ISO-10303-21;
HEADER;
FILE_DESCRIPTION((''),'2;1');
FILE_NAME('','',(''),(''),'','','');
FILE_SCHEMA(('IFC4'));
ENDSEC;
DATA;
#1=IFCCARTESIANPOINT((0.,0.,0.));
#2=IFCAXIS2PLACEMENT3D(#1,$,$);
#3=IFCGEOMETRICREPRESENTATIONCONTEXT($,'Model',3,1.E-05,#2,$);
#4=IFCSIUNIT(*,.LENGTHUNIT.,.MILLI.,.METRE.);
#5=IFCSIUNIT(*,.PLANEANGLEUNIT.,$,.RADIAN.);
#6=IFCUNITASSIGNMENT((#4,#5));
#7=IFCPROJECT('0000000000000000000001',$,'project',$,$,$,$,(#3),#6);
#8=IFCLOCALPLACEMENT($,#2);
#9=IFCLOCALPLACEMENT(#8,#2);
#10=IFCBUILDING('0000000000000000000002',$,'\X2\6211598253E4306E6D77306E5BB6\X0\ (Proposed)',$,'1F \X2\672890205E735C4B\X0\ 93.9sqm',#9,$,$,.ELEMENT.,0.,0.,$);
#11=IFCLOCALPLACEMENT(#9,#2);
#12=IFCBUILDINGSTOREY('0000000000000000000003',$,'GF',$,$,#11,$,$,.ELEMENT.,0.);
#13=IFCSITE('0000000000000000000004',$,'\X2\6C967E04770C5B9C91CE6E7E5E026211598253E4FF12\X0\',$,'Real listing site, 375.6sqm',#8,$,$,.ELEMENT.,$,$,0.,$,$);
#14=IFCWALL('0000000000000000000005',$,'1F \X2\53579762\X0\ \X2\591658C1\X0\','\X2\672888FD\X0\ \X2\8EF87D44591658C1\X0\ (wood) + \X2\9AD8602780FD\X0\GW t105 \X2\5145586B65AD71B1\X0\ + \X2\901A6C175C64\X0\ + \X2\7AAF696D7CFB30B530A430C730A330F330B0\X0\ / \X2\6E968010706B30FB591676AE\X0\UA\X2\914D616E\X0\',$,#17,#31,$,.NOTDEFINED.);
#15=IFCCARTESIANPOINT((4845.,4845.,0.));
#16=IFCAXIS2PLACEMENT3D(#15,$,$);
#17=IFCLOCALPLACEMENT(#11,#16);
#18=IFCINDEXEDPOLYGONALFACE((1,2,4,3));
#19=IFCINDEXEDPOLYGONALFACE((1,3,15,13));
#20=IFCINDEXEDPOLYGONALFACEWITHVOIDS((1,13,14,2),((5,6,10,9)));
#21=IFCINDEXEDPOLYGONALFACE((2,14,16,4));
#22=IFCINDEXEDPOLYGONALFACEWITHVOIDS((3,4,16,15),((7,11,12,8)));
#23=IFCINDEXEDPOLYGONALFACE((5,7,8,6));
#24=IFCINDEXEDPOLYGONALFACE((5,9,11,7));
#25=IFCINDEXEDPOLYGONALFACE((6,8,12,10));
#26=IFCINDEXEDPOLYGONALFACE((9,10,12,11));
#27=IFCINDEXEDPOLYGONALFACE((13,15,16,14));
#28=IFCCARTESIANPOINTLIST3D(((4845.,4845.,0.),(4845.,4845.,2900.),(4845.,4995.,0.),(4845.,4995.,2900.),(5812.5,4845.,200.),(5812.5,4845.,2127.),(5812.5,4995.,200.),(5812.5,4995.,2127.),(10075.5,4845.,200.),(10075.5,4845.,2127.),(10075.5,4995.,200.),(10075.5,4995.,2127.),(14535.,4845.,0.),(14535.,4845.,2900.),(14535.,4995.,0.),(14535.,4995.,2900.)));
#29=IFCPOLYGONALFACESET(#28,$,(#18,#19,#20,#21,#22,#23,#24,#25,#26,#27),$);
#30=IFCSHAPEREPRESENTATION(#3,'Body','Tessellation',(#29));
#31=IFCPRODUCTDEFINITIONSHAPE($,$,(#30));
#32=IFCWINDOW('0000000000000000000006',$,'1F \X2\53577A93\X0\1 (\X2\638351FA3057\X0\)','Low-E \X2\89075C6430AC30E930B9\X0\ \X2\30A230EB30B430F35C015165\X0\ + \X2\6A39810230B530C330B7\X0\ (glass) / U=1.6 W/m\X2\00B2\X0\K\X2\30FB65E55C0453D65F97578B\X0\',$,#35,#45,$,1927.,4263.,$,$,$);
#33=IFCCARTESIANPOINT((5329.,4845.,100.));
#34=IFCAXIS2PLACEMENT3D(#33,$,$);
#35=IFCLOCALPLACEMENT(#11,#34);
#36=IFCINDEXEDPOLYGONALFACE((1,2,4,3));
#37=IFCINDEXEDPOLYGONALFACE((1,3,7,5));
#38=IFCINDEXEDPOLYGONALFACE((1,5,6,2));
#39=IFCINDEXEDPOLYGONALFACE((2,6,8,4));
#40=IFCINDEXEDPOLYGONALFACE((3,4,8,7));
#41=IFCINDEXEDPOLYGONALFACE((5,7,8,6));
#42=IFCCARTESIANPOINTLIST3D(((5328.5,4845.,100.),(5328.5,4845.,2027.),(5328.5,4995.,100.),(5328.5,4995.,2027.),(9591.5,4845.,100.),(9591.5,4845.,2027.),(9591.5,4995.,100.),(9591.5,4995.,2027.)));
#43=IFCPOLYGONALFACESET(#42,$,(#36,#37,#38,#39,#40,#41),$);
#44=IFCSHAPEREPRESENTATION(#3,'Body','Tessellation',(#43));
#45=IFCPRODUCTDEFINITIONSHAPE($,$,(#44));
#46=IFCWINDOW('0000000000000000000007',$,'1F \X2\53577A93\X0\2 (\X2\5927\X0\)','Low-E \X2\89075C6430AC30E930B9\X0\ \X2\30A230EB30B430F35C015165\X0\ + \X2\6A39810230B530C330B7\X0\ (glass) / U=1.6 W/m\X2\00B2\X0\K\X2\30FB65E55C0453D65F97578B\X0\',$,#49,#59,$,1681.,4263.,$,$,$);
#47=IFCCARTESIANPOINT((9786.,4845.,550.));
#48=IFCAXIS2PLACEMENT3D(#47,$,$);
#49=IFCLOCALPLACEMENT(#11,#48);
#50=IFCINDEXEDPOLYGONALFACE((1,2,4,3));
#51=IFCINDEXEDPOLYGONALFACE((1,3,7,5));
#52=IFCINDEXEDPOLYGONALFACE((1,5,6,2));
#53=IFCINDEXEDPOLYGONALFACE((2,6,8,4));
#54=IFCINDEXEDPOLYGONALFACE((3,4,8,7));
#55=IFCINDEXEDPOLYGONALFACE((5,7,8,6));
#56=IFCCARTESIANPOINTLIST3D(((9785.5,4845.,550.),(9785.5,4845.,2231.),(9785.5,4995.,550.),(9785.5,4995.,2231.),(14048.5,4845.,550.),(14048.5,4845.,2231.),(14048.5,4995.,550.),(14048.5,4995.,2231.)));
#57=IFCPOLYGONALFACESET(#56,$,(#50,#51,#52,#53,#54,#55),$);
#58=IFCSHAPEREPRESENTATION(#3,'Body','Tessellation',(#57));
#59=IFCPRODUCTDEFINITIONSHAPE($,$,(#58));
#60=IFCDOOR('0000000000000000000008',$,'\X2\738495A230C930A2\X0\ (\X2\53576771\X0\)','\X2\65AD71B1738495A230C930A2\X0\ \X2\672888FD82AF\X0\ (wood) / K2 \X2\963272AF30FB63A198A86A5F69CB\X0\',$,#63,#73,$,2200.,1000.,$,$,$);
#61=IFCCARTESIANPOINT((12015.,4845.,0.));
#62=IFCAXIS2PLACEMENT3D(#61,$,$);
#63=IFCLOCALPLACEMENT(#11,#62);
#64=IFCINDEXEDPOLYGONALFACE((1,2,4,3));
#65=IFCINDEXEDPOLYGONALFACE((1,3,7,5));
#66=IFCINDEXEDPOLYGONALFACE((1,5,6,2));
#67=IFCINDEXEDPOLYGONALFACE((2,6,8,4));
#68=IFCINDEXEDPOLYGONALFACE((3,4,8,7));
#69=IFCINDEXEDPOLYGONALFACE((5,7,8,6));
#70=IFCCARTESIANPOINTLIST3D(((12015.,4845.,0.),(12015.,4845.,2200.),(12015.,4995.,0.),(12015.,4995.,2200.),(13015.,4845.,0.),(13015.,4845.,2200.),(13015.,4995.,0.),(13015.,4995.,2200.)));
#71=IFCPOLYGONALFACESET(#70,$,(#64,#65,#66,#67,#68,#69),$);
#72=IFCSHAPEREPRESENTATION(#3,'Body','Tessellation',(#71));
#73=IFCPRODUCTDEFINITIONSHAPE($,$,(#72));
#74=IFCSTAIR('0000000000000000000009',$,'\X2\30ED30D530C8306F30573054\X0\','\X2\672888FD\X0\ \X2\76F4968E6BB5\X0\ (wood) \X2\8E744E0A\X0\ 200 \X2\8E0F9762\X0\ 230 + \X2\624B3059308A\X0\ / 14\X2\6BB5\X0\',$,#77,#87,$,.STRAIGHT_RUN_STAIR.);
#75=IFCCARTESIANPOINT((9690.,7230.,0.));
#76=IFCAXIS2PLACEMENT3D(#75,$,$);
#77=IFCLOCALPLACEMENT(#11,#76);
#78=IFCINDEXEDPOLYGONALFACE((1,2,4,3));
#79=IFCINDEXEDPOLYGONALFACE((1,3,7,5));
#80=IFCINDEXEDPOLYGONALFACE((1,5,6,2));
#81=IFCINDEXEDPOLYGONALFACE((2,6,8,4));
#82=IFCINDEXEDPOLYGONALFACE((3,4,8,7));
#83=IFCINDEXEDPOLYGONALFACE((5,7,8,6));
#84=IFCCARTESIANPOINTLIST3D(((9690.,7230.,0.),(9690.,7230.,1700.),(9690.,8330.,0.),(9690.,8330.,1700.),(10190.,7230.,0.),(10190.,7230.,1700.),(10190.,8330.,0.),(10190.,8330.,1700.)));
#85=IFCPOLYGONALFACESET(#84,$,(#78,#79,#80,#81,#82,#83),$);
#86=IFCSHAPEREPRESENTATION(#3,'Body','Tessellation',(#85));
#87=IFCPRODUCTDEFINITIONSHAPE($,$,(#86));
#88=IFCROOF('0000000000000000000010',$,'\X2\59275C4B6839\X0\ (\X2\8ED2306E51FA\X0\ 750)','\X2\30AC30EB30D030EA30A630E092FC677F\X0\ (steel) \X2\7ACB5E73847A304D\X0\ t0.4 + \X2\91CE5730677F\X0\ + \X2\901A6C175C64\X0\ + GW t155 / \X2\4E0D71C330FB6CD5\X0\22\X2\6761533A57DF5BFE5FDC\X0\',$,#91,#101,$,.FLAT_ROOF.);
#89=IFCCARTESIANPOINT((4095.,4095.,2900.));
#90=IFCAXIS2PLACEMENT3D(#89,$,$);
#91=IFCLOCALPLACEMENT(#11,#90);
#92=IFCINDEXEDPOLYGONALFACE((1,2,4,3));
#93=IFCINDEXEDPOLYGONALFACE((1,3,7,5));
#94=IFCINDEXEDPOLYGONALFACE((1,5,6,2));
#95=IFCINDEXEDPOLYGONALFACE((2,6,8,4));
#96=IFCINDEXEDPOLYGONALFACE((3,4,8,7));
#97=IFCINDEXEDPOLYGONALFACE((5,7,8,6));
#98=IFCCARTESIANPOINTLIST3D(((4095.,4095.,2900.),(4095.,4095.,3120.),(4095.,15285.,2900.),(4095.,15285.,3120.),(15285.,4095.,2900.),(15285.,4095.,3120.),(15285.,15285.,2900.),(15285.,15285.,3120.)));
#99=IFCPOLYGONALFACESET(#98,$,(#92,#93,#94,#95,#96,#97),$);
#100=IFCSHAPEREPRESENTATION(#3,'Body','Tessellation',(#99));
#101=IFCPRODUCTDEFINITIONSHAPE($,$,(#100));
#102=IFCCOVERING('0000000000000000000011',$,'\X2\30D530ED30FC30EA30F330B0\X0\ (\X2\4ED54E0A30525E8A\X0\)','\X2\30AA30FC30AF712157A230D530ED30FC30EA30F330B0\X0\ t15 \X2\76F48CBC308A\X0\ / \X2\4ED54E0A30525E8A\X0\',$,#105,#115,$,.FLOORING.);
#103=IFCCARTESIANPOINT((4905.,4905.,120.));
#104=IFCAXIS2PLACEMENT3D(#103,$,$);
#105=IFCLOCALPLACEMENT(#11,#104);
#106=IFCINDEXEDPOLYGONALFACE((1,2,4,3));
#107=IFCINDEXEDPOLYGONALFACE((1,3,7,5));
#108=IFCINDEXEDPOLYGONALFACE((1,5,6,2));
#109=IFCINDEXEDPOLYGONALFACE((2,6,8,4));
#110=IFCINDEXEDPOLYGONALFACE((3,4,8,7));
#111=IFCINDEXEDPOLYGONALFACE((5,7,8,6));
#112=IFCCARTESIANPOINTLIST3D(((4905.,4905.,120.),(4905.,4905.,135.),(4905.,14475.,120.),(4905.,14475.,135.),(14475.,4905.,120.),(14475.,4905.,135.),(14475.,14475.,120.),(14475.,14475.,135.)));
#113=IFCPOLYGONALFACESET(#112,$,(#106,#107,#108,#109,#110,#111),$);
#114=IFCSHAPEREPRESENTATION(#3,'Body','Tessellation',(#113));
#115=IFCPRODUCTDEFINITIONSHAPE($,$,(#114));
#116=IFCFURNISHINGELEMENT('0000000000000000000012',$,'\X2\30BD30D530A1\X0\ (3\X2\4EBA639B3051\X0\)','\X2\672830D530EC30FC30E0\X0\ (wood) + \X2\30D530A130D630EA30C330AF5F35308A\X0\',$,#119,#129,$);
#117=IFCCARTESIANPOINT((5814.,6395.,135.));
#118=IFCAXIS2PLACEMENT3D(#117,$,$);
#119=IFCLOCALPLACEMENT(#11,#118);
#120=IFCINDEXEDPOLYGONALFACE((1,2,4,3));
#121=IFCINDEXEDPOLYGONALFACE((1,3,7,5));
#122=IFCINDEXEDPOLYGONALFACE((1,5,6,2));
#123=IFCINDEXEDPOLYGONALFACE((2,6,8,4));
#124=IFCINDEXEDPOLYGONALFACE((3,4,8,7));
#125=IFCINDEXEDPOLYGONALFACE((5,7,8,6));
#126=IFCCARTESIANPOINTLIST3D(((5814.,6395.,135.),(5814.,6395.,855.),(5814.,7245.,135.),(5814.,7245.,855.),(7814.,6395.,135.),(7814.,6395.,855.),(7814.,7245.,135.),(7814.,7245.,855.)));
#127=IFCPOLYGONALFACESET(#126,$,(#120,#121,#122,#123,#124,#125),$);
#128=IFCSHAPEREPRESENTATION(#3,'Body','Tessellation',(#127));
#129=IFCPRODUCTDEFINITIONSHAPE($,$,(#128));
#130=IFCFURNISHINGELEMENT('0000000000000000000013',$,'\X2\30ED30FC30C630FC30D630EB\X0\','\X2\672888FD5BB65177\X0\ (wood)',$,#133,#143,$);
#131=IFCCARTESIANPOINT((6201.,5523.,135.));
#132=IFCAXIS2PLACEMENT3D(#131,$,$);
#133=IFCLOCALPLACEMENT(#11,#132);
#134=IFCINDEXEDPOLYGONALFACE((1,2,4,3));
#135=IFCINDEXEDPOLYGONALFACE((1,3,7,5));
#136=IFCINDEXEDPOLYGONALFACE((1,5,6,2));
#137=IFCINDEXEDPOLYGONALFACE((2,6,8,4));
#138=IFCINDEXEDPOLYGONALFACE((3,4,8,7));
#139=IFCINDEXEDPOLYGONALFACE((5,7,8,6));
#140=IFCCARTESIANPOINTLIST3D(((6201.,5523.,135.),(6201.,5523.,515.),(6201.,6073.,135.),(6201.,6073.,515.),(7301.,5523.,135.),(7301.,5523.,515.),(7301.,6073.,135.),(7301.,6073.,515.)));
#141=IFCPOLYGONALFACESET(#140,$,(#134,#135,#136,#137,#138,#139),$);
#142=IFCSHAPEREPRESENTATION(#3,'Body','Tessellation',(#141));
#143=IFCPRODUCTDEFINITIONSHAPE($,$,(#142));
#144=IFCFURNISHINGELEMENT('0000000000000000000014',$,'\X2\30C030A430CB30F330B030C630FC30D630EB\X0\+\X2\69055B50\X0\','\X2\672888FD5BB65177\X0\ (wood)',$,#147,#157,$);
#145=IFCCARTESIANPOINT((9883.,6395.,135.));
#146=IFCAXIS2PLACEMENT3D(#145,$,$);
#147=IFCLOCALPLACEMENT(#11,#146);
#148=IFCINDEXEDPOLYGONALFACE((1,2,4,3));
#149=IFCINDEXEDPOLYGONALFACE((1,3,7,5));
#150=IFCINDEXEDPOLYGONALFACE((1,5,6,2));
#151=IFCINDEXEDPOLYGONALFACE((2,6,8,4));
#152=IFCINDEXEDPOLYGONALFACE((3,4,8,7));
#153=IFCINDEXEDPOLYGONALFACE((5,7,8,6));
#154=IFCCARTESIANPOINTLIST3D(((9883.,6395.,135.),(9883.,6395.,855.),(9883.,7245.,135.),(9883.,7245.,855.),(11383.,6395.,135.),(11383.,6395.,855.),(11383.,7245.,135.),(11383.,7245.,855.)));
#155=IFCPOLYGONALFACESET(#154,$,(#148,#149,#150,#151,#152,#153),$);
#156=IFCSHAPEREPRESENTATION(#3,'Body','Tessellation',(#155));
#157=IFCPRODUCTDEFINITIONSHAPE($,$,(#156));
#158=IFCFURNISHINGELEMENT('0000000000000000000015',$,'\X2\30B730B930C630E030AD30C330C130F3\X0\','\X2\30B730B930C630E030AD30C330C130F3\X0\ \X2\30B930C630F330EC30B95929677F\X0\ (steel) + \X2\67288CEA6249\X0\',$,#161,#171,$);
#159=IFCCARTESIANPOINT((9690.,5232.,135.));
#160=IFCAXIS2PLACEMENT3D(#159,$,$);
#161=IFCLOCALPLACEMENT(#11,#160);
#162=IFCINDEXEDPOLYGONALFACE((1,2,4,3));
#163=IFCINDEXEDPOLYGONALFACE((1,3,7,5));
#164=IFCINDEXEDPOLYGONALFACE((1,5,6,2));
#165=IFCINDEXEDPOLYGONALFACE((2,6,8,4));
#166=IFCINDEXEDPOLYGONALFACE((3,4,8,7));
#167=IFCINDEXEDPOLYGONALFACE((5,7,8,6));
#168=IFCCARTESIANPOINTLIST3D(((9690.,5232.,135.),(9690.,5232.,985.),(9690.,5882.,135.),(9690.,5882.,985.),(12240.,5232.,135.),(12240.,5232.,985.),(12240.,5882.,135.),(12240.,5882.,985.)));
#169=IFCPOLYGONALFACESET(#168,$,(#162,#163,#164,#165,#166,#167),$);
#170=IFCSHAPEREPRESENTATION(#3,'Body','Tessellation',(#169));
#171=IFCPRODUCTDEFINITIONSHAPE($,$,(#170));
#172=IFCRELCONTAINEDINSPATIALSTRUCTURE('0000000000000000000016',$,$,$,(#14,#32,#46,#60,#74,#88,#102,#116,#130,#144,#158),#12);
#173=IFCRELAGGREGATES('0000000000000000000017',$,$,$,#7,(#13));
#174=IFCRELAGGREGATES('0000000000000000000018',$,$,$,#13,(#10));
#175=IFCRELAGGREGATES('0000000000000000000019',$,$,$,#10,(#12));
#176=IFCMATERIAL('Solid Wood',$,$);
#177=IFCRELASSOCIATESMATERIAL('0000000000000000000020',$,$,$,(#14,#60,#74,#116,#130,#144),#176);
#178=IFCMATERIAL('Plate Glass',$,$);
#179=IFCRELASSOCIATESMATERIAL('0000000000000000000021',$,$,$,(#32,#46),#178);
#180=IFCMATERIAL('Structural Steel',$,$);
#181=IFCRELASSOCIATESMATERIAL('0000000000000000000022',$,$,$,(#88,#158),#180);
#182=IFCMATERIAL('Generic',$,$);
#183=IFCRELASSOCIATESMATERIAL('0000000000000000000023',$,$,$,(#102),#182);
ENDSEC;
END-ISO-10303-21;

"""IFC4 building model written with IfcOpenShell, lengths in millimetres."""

from ifc_helpers import new_model, si_unit, frame, frame_2d, origin, place, context, project, spatial, rectangle, extrude, material, element, fill, save


model = new_model("IFC4")

# Units and contexts
model_context = context("Model", 3, precision=1e-05, world=origin())
ifc_project = project(units=[si_unit("LENGTHUNIT", "METRE", prefix="MILLI"), si_unit("PLANEANGLEUNIT", "RADIAN")], contexts=[model_context])

# Site, building, storey
site_placement = place(None, origin())
site = spatial("IfcSite", under=ifc_project, at=site_placement, Name="沖縄県宜野湾市我如古２", ObjectType="Real listing site, 375.6sqm", CompositionType="ELEMENT", RefElevation=0.0)
building_placement = place(site_placement, origin())
building = spatial("IfcBuilding", under=site, at=building_placement, Name="我如古の海の家 (Proposed)", ObjectType="1F 木造平屋 93.9sqm", CompositionType="ELEMENT", ElevationOfRefHeight=0.0, ElevationOfTerrain=0.0)
storey_placement = place(building_placement, origin())
storey = spatial("IfcBuildingStorey", under=building, at=storey_placement, Name="GF", CompositionType="ELEMENT", Elevation=0.0)

# Shared definitions
ifc_material_1 = material(Name="Solid Wood")

# Wall, openings, windows, door
wall_1_placement = place(storey_placement, frame((4845.0, 4845.0, 0.0)))
wall_1 = element("IfcWall", 1, at=wall_1_placement, inside=storey, material=ifc_material_1, Name="1F 南面 外壁", Description="木製 軸組外壁 (wood) + 高性能GW t105 充填断熱 + 通気層 + 窯業系サイディング / 準耐火・外皮UA配慮", PredefinedType="NOTDEFINED", context=model_context, shape_type="SweptSolid", body=[
    extrude(rectangle(XDim=9690.0, YDim=150.0, at=frame_2d((4845.0, 75.0))), frame((4845.0, 4845.0, 0.0)), (0.0, 0.0, 1.0), 2900.0),
])
opening_1_placement = place(storey_placement, frame((5329.0, 4845.0, 100.0)))
opening_1 = element("IfcOpeningElement", 2, at=opening_1_placement, cuts=wall_1, PredefinedType="NOTDEFINED", context=model_context, shape_type="SweptSolid", body=[
    extrude(rectangle(XDim=4263.0, YDim=150.0, at=frame_2d((2131.0, 75.0))), frame((5329.0, 4845.0, 100.0)), (0.0, 0.0, 1.0), 1927.0),
])
opening_2_placement = place(storey_placement, frame((9786.0, 4845.0, 550.0)))
opening_2 = element("IfcOpeningElement", 3, at=opening_2_placement, cuts=wall_1, PredefinedType="NOTDEFINED", context=model_context, shape_type="SweptSolid", body=[
    extrude(rectangle(XDim=4263.0, YDim=150.0, at=frame_2d((2131.0, 75.0))), frame((9786.0, 4845.0, 550.0)), (0.0, 0.0, 1.0), 1681.0),
])
opening_3_placement = place(storey_placement, frame((12015.0, 4845.0, 0.0)))
opening_3 = element("IfcOpeningElement", 4, at=opening_3_placement, cuts=wall_1, PredefinedType="NOTDEFINED", context=model_context, shape_type="SweptSolid", body=[
    extrude(rectangle(XDim=1000.0, YDim=150.0, at=frame_2d((500.0, 75.0))), frame((12015.0, 4845.0, 0.0)), (0.0, 0.0, 1.0), 2200.0),
])
ifc_material_2 = material(Name="Plate Glass")
window_1_placement = place(storey_placement, frame((5329.0, 4845.0, 100.0)))
window_1 = element("IfcWindow", 5, at=window_1_placement, inside=storey, material=ifc_material_2, Name="1F 南窓1 (掃出し)", Description="Low-E 複層ガラス アルゴン封入 + 樹脂サッシ (glass) / U=1.6 W/m²K・日射取得型", OverallHeight=1927.0, OverallWidth=4263.0, context=model_context, shape_type="SweptSolid", body=[
    extrude(rectangle(XDim=4263.0, YDim=150.0, at=frame_2d((2131.0, 75.0))), frame((5329.0, 4845.0, 100.0)), (0.0, 0.0, 1.0), 1927.0),
])
fill(opening_1, window_1)
window_2_placement = place(storey_placement, frame((9786.0, 4845.0, 550.0)))
window_2 = element("IfcWindow", 6, at=window_2_placement, inside=storey, material=ifc_material_2, Name="1F 南窓2 (大)", Description="Low-E 複層ガラス アルゴン封入 + 樹脂サッシ (glass) / U=1.6 W/m²K・日射取得型", OverallHeight=1681.0, OverallWidth=4263.0, context=model_context, shape_type="SweptSolid", body=[
    extrude(rectangle(XDim=4263.0, YDim=150.0, at=frame_2d((2131.0, 75.0))), frame((9786.0, 4845.0, 550.0)), (0.0, 0.0, 1.0), 1681.0),
])
fill(opening_2, window_2)
door_placement = place(storey_placement, frame((12015.0, 4845.0, 0.0)))
door = element("IfcDoor", 7, at=door_placement, inside=storey, material=ifc_material_1, Name="玄関ドア (南東)", Description="断熱玄関ドア 木製芯 (wood) / K2 防犯・採風機構", OverallHeight=2200.0, OverallWidth=1000.0, context=model_context, shape_type="SweptSolid", body=[
    extrude(rectangle(XDim=1000.0, YDim=150.0, at=frame_2d((500.0, 75.0))), frame((12015.0, 4845.0, 0.0)), (0.0, 0.0, 1.0), 2200.0),
])
fill(opening_3, door)

# Stair
stair_placement = place(storey_placement, frame((9690.0, 7230.0, 0.0)))
element("IfcStair", 8, at=stair_placement, inside=storey, material=ifc_material_1, Name="ロフトはしご", Description="木製 直階段 (wood) 蹴上 200 踏面 230 + 手すり / 14段", PredefinedType="STRAIGHT_RUN_STAIR", context=model_context, shape_type="SweptSolid", body=[
    extrude(rectangle(XDim=500.0, YDim=1100.0, at=frame_2d((250.0, 550.0))), frame((9690.0, 7230.0, 0.0)), (0.0, 0.0, 1.0), 1700.0),
])

# Roof
ifc_material_3 = material(Name="Structural Steel")
roof_placement = place(storey_placement, frame((4095.0, 4095.0, 2900.0)))
element("IfcRoof", 9, at=roof_placement, inside=storey, material=ifc_material_3, Name="大屋根 (軒の出 750)", Description="ガルバリウム鋼板 (steel) 立平葺き t0.4 + 野地板 + 通気層 + GW t155 / 不燃・法22条区域対応", PredefinedType="FLAT_ROOF", context=model_context, shape_type="SweptSolid", body=[
    extrude(rectangle(XDim=11190.0, YDim=11190.0, at=frame_2d((5595.0, 5595.0))), frame((4095.0, 4095.0, 2900.0)), (0.0, 0.0, 1.0), 220.0),
])

# Covering
ifc_material_4 = material(Name="Generic")
covering_placement = place(storey_placement, frame((4905.0, 4905.0, 120.0)))
element("IfcCovering", 10, at=covering_placement, inside=storey, material=ifc_material_4, Name="フローリング (仕上げ床)", Description="オーク無垢フローリング t15 直貼り / 仕上げ床", PredefinedType="FLOORING", context=model_context, shape_type="SweptSolid", body=[
    extrude(rectangle(XDim=9570.0, YDim=9570.0, at=frame_2d((4785.0, 4785.0))), frame((4905.0, 4905.0, 120.0)), (0.0, 0.0, 1.0), 15.0),
])

# Furnishing elements
furnishing_1_placement = place(storey_placement, frame((5814.0, 6395.0, 135.0)))
element("IfcFurnishingElement", 11, at=furnishing_1_placement, inside=storey, material=ifc_material_1, Name="ソファ (3人掛け)", Description="木フレーム (wood) + ファブリック張り", context=model_context, shape_type="SweptSolid", body=[
    extrude(rectangle(XDim=2000.0, YDim=850.0, at=frame_2d((1000.0, 425.0))), frame((5814.0, 6395.0, 135.0)), (0.0, 0.0, 1.0), 720.0),
])
furnishing_2_placement = place(storey_placement, frame((6201.0, 5523.0, 135.0)))
element("IfcFurnishingElement", 12, at=furnishing_2_placement, inside=storey, material=ifc_material_1, Name="ローテーブル", Description="木製家具 (wood)", context=model_context, shape_type="SweptSolid", body=[
    extrude(rectangle(XDim=1100.0, YDim=550.0, at=frame_2d((550.0, 275.0))), frame((6201.0, 5523.0, 135.0)), (0.0, 0.0, 1.0), 380.0),
])
furnishing_3_placement = place(storey_placement, frame((9883.0, 6395.0, 135.0)))
element("IfcFurnishingElement", 13, at=furnishing_3_placement, inside=storey, material=ifc_material_1, Name="ダイニングテーブル+椅子", Description="木製家具 (wood)", context=model_context, shape_type="SweptSolid", body=[
    extrude(rectangle(XDim=1500.0, YDim=850.0, at=frame_2d((750.0, 425.0))), frame((9883.0, 6395.0, 135.0)), (0.0, 0.0, 1.0), 720.0),
])
furnishing_4_placement = place(storey_placement, frame((9690.0, 5232.0, 135.0)))
element("IfcFurnishingElement", 14, at=furnishing_4_placement, inside=storey, material=ifc_material_3, Name="システムキッチン", Description="システムキッチン ステンレス天板 (steel) + 木質扉", context=model_context, shape_type="SweptSolid", body=[
    extrude(rectangle(XDim=2550.0, YDim=650.0, at=frame_2d((1275.0, 325.0))), frame((9690.0, 5232.0, 135.0)), (0.0, 0.0, 1.0), 850.0),
])

save(model, "model.ifc")
